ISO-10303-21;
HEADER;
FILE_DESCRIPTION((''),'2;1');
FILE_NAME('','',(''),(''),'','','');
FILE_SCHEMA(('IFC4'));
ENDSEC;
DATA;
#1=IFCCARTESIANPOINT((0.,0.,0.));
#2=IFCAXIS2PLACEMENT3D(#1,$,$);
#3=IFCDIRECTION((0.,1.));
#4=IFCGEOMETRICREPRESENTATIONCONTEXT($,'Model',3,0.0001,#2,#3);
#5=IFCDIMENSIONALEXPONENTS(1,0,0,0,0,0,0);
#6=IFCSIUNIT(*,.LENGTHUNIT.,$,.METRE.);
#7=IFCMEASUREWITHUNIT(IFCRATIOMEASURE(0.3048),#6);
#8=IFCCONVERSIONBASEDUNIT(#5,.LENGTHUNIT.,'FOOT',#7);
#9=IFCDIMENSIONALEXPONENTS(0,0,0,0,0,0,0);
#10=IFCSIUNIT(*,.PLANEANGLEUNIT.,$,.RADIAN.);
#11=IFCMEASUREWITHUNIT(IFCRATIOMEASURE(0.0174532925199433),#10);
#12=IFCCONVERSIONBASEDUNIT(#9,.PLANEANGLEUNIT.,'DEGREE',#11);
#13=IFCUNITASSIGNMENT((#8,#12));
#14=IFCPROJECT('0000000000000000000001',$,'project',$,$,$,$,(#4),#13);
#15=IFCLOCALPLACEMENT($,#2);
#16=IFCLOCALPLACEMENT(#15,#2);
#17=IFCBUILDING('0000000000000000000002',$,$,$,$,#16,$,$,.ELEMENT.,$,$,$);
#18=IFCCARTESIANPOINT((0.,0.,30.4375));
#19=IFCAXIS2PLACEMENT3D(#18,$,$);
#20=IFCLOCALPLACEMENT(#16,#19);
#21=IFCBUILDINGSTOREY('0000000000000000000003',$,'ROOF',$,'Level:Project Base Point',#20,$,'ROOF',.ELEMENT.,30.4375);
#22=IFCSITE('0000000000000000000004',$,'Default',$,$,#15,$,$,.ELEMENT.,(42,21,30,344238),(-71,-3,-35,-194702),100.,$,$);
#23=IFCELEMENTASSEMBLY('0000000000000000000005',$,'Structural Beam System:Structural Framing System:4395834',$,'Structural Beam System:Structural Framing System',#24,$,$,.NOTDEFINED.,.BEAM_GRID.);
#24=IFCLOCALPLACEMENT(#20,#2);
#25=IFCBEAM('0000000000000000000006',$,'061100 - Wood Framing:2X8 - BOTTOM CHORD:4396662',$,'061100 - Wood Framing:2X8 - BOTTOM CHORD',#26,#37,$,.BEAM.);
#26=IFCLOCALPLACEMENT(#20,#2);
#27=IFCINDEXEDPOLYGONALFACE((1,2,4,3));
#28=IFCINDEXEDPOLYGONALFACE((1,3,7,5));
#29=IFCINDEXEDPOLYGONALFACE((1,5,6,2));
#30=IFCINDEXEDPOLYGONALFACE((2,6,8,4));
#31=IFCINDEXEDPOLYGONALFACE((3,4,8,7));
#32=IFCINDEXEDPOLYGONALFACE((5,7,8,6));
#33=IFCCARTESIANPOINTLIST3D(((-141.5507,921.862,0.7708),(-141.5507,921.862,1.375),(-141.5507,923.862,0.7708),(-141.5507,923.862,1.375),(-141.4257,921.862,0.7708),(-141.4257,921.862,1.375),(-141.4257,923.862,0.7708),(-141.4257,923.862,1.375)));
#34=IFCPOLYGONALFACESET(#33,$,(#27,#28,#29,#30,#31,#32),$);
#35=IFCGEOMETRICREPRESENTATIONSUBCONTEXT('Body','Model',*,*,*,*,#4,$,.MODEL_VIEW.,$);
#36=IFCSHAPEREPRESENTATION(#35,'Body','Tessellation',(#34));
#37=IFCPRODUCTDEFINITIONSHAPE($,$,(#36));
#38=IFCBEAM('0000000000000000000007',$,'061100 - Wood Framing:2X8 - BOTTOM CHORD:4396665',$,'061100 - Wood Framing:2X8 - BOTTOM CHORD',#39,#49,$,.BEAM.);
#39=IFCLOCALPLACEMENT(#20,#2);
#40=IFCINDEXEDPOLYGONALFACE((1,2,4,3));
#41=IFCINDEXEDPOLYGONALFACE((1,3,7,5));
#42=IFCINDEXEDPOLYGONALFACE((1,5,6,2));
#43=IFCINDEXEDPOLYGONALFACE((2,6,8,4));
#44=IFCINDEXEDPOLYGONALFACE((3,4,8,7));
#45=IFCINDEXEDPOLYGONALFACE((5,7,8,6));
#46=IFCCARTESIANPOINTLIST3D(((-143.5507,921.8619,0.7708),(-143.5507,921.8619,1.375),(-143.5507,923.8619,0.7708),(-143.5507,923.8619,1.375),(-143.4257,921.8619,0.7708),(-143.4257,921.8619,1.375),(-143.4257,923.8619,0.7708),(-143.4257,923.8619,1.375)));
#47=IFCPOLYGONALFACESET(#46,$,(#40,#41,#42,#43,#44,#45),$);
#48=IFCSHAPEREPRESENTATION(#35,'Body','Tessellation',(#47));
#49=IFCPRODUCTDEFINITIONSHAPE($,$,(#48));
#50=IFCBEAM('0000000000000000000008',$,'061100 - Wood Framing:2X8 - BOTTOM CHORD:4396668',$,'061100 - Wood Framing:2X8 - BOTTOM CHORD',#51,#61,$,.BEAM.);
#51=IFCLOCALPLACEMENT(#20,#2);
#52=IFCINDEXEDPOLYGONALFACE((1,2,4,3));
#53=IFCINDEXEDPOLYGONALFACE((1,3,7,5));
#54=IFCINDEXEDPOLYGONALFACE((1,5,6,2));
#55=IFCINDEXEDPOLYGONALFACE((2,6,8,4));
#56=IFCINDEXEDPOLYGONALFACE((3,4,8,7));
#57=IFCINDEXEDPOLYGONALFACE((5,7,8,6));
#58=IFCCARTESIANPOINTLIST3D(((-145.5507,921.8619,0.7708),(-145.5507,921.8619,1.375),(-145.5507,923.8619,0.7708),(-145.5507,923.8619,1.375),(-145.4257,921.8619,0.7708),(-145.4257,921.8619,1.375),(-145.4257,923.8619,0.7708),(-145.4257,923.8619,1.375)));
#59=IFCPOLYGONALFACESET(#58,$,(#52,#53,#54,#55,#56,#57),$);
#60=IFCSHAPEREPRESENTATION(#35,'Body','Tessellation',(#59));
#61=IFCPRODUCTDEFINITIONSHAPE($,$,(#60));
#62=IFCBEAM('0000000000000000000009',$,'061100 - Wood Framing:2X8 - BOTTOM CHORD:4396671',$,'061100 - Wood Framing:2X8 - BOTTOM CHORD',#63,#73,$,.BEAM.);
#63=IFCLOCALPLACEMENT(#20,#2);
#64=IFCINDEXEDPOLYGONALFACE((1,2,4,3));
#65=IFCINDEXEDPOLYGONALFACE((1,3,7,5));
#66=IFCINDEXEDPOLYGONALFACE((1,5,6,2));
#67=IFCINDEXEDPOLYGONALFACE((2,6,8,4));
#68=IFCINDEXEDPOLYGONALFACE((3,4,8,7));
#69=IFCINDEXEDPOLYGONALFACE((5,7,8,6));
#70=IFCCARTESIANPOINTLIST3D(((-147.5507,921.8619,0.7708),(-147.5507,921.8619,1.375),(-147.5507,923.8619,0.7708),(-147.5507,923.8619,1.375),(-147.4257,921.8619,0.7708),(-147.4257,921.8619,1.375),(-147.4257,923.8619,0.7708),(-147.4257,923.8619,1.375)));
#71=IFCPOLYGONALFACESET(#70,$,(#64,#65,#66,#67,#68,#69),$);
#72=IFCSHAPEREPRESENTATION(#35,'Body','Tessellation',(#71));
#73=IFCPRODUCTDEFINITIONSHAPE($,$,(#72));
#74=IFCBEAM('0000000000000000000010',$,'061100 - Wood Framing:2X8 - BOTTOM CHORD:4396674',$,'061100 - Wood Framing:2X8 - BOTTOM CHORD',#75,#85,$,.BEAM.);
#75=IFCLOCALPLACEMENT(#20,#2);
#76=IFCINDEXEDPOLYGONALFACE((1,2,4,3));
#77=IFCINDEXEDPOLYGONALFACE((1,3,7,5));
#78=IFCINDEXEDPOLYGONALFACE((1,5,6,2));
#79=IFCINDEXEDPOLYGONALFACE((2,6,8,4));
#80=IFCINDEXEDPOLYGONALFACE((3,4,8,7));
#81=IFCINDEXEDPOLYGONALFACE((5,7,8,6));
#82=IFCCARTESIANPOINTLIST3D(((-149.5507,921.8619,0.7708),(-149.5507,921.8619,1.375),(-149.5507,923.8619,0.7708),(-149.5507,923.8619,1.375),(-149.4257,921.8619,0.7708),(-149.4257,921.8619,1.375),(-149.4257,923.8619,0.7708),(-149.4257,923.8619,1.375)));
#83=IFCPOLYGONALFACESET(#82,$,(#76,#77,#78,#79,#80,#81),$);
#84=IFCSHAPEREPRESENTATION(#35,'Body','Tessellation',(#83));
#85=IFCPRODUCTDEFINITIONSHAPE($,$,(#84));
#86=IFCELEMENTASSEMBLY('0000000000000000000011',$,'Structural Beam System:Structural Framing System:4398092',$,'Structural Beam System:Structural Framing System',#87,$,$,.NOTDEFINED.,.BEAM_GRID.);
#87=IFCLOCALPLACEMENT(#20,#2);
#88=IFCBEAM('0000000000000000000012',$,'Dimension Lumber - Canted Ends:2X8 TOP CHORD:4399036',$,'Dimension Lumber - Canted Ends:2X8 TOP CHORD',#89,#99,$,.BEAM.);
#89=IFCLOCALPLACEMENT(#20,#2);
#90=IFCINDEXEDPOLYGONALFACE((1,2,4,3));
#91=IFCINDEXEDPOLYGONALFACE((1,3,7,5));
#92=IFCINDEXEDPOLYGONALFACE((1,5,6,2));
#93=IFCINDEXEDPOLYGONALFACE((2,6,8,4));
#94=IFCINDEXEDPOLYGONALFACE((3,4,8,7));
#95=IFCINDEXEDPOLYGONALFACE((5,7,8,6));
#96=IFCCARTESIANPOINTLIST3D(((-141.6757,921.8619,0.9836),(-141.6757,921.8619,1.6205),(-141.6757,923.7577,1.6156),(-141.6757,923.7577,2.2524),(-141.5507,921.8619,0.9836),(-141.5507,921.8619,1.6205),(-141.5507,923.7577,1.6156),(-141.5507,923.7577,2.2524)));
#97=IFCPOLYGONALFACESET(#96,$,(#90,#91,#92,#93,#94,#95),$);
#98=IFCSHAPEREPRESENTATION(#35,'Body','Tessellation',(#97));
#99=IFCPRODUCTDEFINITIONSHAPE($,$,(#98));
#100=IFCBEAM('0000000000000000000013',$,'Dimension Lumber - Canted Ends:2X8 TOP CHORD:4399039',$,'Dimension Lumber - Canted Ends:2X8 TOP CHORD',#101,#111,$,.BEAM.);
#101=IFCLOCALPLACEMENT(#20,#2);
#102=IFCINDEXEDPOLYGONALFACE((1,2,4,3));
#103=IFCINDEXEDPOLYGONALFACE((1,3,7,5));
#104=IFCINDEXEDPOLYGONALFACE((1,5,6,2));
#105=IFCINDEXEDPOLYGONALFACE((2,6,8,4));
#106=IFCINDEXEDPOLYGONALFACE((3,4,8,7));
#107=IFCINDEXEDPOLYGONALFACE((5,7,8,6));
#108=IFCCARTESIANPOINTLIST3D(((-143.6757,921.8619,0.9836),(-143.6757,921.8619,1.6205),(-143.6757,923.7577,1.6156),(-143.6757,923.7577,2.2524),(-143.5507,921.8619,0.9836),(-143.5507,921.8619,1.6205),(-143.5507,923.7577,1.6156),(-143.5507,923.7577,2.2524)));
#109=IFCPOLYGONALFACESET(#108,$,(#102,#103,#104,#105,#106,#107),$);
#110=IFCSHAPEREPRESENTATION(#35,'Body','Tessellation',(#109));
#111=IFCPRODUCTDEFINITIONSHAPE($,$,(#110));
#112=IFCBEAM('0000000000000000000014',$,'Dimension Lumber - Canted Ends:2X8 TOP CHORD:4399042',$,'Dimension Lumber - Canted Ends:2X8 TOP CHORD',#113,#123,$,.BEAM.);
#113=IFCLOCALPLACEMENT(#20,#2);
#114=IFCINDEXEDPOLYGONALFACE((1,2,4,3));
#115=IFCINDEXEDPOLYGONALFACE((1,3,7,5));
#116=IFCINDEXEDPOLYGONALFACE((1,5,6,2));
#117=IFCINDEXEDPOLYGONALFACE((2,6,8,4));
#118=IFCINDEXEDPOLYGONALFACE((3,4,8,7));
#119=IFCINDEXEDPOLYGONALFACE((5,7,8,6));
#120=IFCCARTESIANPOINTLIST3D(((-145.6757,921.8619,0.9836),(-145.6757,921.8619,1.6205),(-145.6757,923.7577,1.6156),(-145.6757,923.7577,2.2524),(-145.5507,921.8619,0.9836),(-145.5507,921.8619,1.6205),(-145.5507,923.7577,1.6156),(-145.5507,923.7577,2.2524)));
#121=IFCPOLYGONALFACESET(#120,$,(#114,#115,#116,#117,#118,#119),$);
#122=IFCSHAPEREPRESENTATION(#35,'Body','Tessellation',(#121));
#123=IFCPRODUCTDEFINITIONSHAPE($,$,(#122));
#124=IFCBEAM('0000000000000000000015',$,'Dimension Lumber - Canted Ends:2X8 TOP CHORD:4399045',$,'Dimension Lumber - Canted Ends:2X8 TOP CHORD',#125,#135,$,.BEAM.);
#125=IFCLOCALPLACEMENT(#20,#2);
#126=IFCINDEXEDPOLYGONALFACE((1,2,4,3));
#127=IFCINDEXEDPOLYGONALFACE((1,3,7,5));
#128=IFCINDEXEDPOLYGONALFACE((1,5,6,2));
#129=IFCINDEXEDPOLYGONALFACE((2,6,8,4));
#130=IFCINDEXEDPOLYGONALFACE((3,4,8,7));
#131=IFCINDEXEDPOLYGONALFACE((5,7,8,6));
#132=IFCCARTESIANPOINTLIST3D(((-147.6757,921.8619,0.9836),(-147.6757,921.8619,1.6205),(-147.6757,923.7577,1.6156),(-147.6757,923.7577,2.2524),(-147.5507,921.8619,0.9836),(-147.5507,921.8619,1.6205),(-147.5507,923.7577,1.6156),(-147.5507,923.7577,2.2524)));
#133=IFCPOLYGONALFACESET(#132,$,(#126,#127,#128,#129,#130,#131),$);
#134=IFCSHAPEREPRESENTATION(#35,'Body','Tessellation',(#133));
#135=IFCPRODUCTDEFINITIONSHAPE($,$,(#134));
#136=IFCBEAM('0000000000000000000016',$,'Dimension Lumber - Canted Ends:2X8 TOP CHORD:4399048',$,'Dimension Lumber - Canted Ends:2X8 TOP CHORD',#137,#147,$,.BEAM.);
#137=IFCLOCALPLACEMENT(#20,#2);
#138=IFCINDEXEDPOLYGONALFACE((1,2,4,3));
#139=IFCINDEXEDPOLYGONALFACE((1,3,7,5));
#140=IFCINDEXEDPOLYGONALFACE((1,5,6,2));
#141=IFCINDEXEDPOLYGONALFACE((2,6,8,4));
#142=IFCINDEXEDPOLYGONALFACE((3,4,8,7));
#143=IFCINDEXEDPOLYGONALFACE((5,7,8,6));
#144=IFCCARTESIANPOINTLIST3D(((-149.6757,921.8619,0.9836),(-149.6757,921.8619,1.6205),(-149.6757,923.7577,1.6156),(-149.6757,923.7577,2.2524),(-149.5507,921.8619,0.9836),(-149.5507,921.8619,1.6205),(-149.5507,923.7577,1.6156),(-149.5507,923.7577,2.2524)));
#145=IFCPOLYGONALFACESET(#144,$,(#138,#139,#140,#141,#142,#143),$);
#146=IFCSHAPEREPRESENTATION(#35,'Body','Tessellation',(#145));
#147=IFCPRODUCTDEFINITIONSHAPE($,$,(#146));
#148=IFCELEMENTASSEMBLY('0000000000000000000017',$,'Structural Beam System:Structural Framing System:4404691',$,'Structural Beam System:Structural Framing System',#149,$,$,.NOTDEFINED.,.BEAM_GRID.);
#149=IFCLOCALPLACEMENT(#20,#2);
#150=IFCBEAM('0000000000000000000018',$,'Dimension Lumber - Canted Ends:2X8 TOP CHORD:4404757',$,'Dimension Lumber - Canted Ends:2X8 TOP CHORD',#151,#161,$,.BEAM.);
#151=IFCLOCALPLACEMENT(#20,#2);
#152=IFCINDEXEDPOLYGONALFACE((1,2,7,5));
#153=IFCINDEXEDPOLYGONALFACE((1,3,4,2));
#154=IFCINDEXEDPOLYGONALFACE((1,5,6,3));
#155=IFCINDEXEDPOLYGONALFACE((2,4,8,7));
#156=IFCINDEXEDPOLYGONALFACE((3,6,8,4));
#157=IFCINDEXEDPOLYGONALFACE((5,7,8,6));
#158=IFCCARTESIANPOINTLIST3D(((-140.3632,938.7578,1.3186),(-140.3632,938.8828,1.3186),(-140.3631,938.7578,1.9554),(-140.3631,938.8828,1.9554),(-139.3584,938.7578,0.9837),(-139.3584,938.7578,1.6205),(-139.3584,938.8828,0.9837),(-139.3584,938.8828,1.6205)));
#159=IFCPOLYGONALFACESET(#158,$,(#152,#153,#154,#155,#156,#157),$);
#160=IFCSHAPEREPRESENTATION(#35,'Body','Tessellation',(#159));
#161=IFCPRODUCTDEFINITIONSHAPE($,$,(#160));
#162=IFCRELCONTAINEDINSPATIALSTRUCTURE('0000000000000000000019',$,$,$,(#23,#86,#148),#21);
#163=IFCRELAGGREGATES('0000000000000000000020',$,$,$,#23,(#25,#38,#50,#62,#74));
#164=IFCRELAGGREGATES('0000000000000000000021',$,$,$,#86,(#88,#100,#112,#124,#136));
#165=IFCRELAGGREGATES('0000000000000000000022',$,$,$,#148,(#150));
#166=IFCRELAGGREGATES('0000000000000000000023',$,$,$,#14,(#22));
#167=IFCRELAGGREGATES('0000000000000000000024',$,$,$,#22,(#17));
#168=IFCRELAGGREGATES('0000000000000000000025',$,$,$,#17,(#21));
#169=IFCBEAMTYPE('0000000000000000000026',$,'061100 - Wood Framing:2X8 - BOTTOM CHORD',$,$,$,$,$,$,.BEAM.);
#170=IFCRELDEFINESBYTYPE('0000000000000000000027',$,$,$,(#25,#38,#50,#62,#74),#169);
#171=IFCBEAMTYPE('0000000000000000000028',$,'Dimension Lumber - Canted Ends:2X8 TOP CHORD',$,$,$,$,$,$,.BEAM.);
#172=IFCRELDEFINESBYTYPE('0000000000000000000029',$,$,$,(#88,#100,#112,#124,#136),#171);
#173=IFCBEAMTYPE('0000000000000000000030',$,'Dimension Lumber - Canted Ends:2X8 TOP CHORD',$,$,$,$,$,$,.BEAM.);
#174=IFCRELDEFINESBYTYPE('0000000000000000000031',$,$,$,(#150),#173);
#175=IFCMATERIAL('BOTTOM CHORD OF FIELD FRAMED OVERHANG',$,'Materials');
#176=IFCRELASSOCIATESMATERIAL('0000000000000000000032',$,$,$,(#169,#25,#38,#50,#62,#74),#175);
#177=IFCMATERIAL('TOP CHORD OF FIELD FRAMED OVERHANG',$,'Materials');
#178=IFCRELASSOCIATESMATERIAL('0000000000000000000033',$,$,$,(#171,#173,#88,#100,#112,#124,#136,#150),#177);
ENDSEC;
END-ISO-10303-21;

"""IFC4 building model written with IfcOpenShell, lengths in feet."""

from ifc_helpers import new_model, entity, si_unit, converted_unit, direction, frame, frame_2d, origin, origin_2d_with_axis, place, context, subcontext, project, spatial, rectangle, extrude, clip, halfspace, source, transform, mapped, material, material_profile, profile_set, profile_usage, type_object, type_shapes, element, aggregate, save


model = new_model("IFC4")

# Units and contexts
model_context = context("Model", 3, precision=0.0001, world=origin(), true_north=direction((0.0, 1.0)))
body_context = subcontext(model_context, "Body", "Model", "MODEL_VIEW")
ifc_project = project(units=[converted_unit("LENGTHUNIT", "FOOT", entity("IfcRatioMeasure", 0.3048), si_unit("LENGTHUNIT", "METRE"), dimensions=[1, 0, 0, 0, 0, 0, 0]), converted_unit("PLANEANGLEUNIT", "DEGREE", entity("IfcRatioMeasure", 0.0174532925199433), si_unit("PLANEANGLEUNIT", "RADIAN"), dimensions=[0, 0, 0, 0, 0, 0, 0])], contexts=[model_context])

# Site, building, storey
site_placement = place(None, origin())
site = spatial("IfcSite", under=ifc_project, at=site_placement, Name="Default", CompositionType="ELEMENT", RefLatitude=(42, 21, 30, 344238), RefLongitude=(-71, -3, -35, -194702), RefElevation=100.0)
building_placement = place(site_placement, origin())
building = spatial("IfcBuilding", under=site, at=building_placement, CompositionType="ELEMENT")
storey_placement = place(building_placement, frame((0.0, 0.0, 30.4375)))
storey = spatial("IfcBuildingStorey", under=building, at=storey_placement, Name="ROOF", ObjectType="Level:Project Base Point", LongName="ROOF", CompositionType="ELEMENT", Elevation=30.4375)

# Element assemblies, beams
assembly_1_placement = place(storey_placement, origin())
assembly_1 = element("IfcElementAssembly", 1, at=assembly_1_placement, inside=storey, Name="Structural Beam System:Structural Framing System:4395834", ObjectType="Structural Beam System:Structural Framing System", AssemblyPlace="NOTDEFINED", PredefinedType="BEAM_GRID")
ifc_material_1 = material(Name="BOTTOM CHORD OF FIELD FRAMED OVERHANG", Category="Materials")
ifc_material_profile_1 = material_profile(ifc_material_1, rectangle(XDim=0.6042, YDim=0.125, at=origin_2d_with_axis()), Name="2X8 - BOTTOM CHORD")
ifc_profile_set_1 = profile_set([ifc_material_profile_1], Name="2X8 - BOTTOM CHORD")
ifc_profile_usage_1 = profile_usage(ifc_profile_set_1, cardinal=8)
beam_type_1 = type_object("IfcBeamType", Name="061100 - Wood Framing:2X8 - BOTTOM CHORD", PredefinedType="BEAM", material=ifc_profile_set_1)
shared_shape_1 = source(origin(), body_context, "Body", "SweptSolid", [
    extrude(rectangle(XDim=0.6042, YDim=0.125, at=origin_2d_with_axis()), frame((-1.0, 0.0, 0.0), z_axis=(1.0, 0.0, 0.0), x_axis=(0.0, 0.0, -1.0)), (0.0, 0.0, 1.0), 2.0),
])
type_shapes(beam_type_1, [shared_shape_1])
beam_1_placement = place(assembly_1_placement, frame((-141.4882, 922.862, 1.0729), z_axis=(0.0, 0.0, 1.0), x_axis=(0.0, -1.0, 0.0)))
beam_1 = element("IfcBeam", 2, at=beam_1_placement, type_object=beam_type_1, material=ifc_profile_usage_1, Name="061100 - Wood Framing:2X8 - BOTTOM CHORD:4396662", ObjectType="061100 - Wood Framing:2X8 - BOTTOM CHORD", PredefinedType="BEAM", context=body_context, shape_type="MappedRepresentation", body=[
    mapped(shared_shape_1, transform((0.0, 0.0, 0.0), scale=1.0)),
])
ifc_profile_usage_2 = profile_usage(ifc_profile_set_1, cardinal=8)
beam_2_placement = place(assembly_1_placement, frame((-143.4882, 922.8619, 1.0729), z_axis=(0.0, 0.0, 1.0), x_axis=(0.0, -1.0, 0.0)))
beam_2 = element("IfcBeam", 3, at=beam_2_placement, type_object=beam_type_1, material=ifc_profile_usage_2, Name="061100 - Wood Framing:2X8 - BOTTOM CHORD:4396665", ObjectType="061100 - Wood Framing:2X8 - BOTTOM CHORD", PredefinedType="BEAM", context=body_context, shape_type="MappedRepresentation", body=[
    mapped(shared_shape_1, transform((0.0, 0.0, 0.0), scale=1.0)),
])
ifc_profile_usage_3 = profile_usage(ifc_profile_set_1, cardinal=8)
beam_3_placement = place(assembly_1_placement, frame((-145.4882, 922.8619, 1.0729), z_axis=(0.0, 0.0, 1.0), x_axis=(0.0, -1.0, 0.0)))
beam_3 = element("IfcBeam", 4, at=beam_3_placement, type_object=beam_type_1, material=ifc_profile_usage_3, Name="061100 - Wood Framing:2X8 - BOTTOM CHORD:4396668", ObjectType="061100 - Wood Framing:2X8 - BOTTOM CHORD", PredefinedType="BEAM", context=body_context, shape_type="MappedRepresentation", body=[
    mapped(shared_shape_1, transform((0.0, 0.0, 0.0), scale=1.0)),
])
ifc_profile_usage_4 = profile_usage(ifc_profile_set_1, cardinal=8)
beam_4_placement = place(assembly_1_placement, frame((-147.4882, 922.8619, 1.0729), z_axis=(0.0, 0.0, 1.0), x_axis=(0.0, -1.0, 0.0)))
beam_4 = element("IfcBeam", 5, at=beam_4_placement, type_object=beam_type_1, material=ifc_profile_usage_4, Name="061100 - Wood Framing:2X8 - BOTTOM CHORD:4396671", ObjectType="061100 - Wood Framing:2X8 - BOTTOM CHORD", PredefinedType="BEAM", context=body_context, shape_type="MappedRepresentation", body=[
    mapped(shared_shape_1, transform((0.0, 0.0, 0.0), scale=1.0)),
])
ifc_profile_usage_5 = profile_usage(ifc_profile_set_1, cardinal=8)
beam_5_placement = place(assembly_1_placement, frame((-149.4882, 922.8619, 1.0729), z_axis=(0.0, 0.0, 1.0), x_axis=(0.0, -1.0, 0.0)))
beam_5 = element("IfcBeam", 6, at=beam_5_placement, type_object=beam_type_1, material=ifc_profile_usage_5, Name="061100 - Wood Framing:2X8 - BOTTOM CHORD:4396674", ObjectType="061100 - Wood Framing:2X8 - BOTTOM CHORD", PredefinedType="BEAM", context=body_context, shape_type="MappedRepresentation", body=[
    mapped(shared_shape_1, transform((0.0, 0.0, 0.0), scale=1.0)),
])
aggregate(assembly_1, [beam_1, beam_2, beam_3, beam_4, beam_5])
assembly_2_placement = place(storey_placement, origin())
assembly_2 = element("IfcElementAssembly", 7, at=assembly_2_placement, inside=storey, Name="Structural Beam System:Structural Framing System:4398092", ObjectType="Structural Beam System:Structural Framing System", AssemblyPlace="NOTDEFINED", PredefinedType="BEAM_GRID")
ifc_material_2 = material(Name="TOP CHORD OF FIELD FRAMED OVERHANG", Category="Materials")
ifc_material_profile_2 = material_profile(ifc_material_2, rectangle(XDim=0.6042, YDim=0.125, at=origin_2d_with_axis()), Name="2X8 TOP CHORD")
ifc_profile_set_2 = profile_set([ifc_material_profile_2], Name="2X8 TOP CHORD")
ifc_profile_usage_6 = profile_usage(ifc_profile_set_2, cardinal=8)
beam_type_2 = type_object("IfcBeamType", Name="Dimension Lumber - Canted Ends:2X8 TOP CHORD", PredefinedType="BEAM", material=ifc_profile_set_2)
shared_shape_2 = source(origin(), body_context, "Body", "Clipping", [
    clip(clip(extrude(rectangle(XDim=0.6042, YDim=0.125, at=origin_2d_with_axis()), frame((-0.9992, 0.0, 0.0), z_axis=(1.0, 0.0, 0.0), x_axis=(0.0, 0.0, -1.0)), (0.0, 0.0, 1.0), 2.1997), halfspace(frame((0.9992, -0.0625, -0.3021), z_axis=(0.948711, 0.0, -0.316146), x_axis=(0.0, 1.0, 0.0)), False)), halfspace(frame((-0.7979, -0.0625, 0.3021), z_axis=(-0.948711, 0.0, 0.316146), x_axis=(0.0, 1.0, 0.0)), False)),
])
type_shapes(beam_type_2, [shared_shape_2])
beam_6_placement = place(assembly_2_placement, frame((-141.6132, 922.7143, 1.5862), z_axis=(0.0, -0.316228, 0.948683), x_axis=(0.0, 0.948683, 0.316228)))
beam_6 = element("IfcBeam", 8, at=beam_6_placement, type_object=beam_type_2, material=ifc_profile_usage_6, Name="Dimension Lumber - Canted Ends:2X8 TOP CHORD:4399036", ObjectType="Dimension Lumber - Canted Ends:2X8 TOP CHORD", PredefinedType="BEAM", context=body_context, shape_type="MappedRepresentation", body=[
    mapped(shared_shape_2, transform((0.0, 0.0, 0.0), scale=1.0)),
])
ifc_profile_usage_7 = profile_usage(ifc_profile_set_2, cardinal=8)
beam_7_placement = place(assembly_2_placement, frame((-143.6132, 922.7143, 1.5862), z_axis=(0.0, -0.316228, 0.948683), x_axis=(0.0, 0.948683, 0.316228)))
beam_7 = element("IfcBeam", 9, at=beam_7_placement, type_object=beam_type_2, material=ifc_profile_usage_7, Name="Dimension Lumber - Canted Ends:2X8 TOP CHORD:4399039", ObjectType="Dimension Lumber - Canted Ends:2X8 TOP CHORD", PredefinedType="BEAM", context=body_context, shape_type="MappedRepresentation", body=[
    mapped(shared_shape_2, transform((0.0, 0.0, 0.0), scale=1.0)),
])
ifc_profile_usage_8 = profile_usage(ifc_profile_set_2, cardinal=8)
beam_8_placement = place(assembly_2_placement, frame((-145.6132, 922.7143, 1.5862), z_axis=(0.0, -0.316228, 0.948683), x_axis=(0.0, 0.948683, 0.316228)))
beam_8 = element("IfcBeam", 10, at=beam_8_placement, type_object=beam_type_2, material=ifc_profile_usage_8, Name="Dimension Lumber - Canted Ends:2X8 TOP CHORD:4399042", ObjectType="Dimension Lumber - Canted Ends:2X8 TOP CHORD", PredefinedType="BEAM", context=body_context, shape_type="MappedRepresentation", body=[
    mapped(shared_shape_2, transform((0.0, 0.0, 0.0), scale=1.0)),
])
ifc_profile_usage_9 = profile_usage(ifc_profile_set_2, cardinal=8)
beam_9_placement = place(assembly_2_placement, frame((-147.6132, 922.7143, 1.5862), z_axis=(0.0, -0.316228, 0.948683), x_axis=(0.0, 0.948683, 0.316228)))
beam_9 = element("IfcBeam", 11, at=beam_9_placement, type_object=beam_type_2, material=ifc_profile_usage_9, Name="Dimension Lumber - Canted Ends:2X8 TOP CHORD:4399045", ObjectType="Dimension Lumber - Canted Ends:2X8 TOP CHORD", PredefinedType="BEAM", context=body_context, shape_type="MappedRepresentation", body=[
    mapped(shared_shape_2, transform((0.0, 0.0, 0.0), scale=1.0)),
])
ifc_profile_usage_10 = profile_usage(ifc_profile_set_2, cardinal=8)
beam_10_placement = place(assembly_2_placement, frame((-149.6132, 922.7143, 1.5862), z_axis=(0.0, -0.316228, 0.948683), x_axis=(0.0, 0.948683, 0.316228)))
beam_10 = element("IfcBeam", 12, at=beam_10_placement, type_object=beam_type_2, material=ifc_profile_usage_10, Name="Dimension Lumber - Canted Ends:2X8 TOP CHORD:4399048", ObjectType="Dimension Lumber - Canted Ends:2X8 TOP CHORD", PredefinedType="BEAM", context=body_context, shape_type="MappedRepresentation", body=[
    mapped(shared_shape_2, transform((0.0, 0.0, 0.0), scale=1.0)),
])
aggregate(assembly_2, [beam_6, beam_7, beam_8, beam_9, beam_10])
assembly_3_placement = place(storey_placement, origin())
assembly_3 = element("IfcElementAssembly", 13, at=assembly_3_placement, inside=storey, Name="Structural Beam System:Structural Framing System:4404691", ObjectType="Structural Beam System:Structural Framing System", AssemblyPlace="NOTDEFINED", PredefinedType="BEAM_GRID")
ifc_profile_usage_11 = profile_usage(ifc_profile_set_2, cardinal=8)
beam_type_3 = type_object("IfcBeamType", Name="Dimension Lumber - Canted Ends:2X8 TOP CHORD", PredefinedType="BEAM", material=ifc_profile_set_2)
shared_shape_3 = source(origin(), body_context, "Body", "Clipping", [
    clip(clip(extrude(rectangle(XDim=0.6042, YDim=0.125, at=frame_2d((0.0, 0.0), x_axis=(1.0, 0.0))), frame((-0.5296, 0.0, 0.0), z_axis=(1.0, 0.0, 0.0), x_axis=(0.0, 0.0, -1.0)), (0.0, 0.0, 1.0), 1.2605), halfspace(frame((0.5296, -0.0625, -0.3021), z_axis=(0.948711, 0.0, -0.316146), x_axis=(0.0, 1.0, 0.0)), False)), halfspace(frame((-0.3282, -0.0625, 0.3021), z_axis=(-0.948711, 0.0, 0.316146), x_axis=(0.0, 1.0, 0.0)), False)),
])
type_shapes(beam_type_3, [shared_shape_3])
beam_11_placement = place(assembly_3_placement, frame((-139.7653, 938.8203, 1.4377), z_axis=(0.316228, 0.0, 0.948683), x_axis=(-0.948683, 0.0, 0.316228)))
beam_11 = element("IfcBeam", 14, at=beam_11_placement, type_object=beam_type_3, material=ifc_profile_usage_11, Name="Dimension Lumber - Canted Ends:2X8 TOP CHORD:4404757", ObjectType="Dimension Lumber - Canted Ends:2X8 TOP CHORD", PredefinedType="BEAM", context=body_context, shape_type="MappedRepresentation", body=[
    mapped(shared_shape_3, transform((0.0, 0.0, 0.0), scale=1.0)),
])
aggregate(assembly_3, [beam_11])

save(model, "model.ifc")
